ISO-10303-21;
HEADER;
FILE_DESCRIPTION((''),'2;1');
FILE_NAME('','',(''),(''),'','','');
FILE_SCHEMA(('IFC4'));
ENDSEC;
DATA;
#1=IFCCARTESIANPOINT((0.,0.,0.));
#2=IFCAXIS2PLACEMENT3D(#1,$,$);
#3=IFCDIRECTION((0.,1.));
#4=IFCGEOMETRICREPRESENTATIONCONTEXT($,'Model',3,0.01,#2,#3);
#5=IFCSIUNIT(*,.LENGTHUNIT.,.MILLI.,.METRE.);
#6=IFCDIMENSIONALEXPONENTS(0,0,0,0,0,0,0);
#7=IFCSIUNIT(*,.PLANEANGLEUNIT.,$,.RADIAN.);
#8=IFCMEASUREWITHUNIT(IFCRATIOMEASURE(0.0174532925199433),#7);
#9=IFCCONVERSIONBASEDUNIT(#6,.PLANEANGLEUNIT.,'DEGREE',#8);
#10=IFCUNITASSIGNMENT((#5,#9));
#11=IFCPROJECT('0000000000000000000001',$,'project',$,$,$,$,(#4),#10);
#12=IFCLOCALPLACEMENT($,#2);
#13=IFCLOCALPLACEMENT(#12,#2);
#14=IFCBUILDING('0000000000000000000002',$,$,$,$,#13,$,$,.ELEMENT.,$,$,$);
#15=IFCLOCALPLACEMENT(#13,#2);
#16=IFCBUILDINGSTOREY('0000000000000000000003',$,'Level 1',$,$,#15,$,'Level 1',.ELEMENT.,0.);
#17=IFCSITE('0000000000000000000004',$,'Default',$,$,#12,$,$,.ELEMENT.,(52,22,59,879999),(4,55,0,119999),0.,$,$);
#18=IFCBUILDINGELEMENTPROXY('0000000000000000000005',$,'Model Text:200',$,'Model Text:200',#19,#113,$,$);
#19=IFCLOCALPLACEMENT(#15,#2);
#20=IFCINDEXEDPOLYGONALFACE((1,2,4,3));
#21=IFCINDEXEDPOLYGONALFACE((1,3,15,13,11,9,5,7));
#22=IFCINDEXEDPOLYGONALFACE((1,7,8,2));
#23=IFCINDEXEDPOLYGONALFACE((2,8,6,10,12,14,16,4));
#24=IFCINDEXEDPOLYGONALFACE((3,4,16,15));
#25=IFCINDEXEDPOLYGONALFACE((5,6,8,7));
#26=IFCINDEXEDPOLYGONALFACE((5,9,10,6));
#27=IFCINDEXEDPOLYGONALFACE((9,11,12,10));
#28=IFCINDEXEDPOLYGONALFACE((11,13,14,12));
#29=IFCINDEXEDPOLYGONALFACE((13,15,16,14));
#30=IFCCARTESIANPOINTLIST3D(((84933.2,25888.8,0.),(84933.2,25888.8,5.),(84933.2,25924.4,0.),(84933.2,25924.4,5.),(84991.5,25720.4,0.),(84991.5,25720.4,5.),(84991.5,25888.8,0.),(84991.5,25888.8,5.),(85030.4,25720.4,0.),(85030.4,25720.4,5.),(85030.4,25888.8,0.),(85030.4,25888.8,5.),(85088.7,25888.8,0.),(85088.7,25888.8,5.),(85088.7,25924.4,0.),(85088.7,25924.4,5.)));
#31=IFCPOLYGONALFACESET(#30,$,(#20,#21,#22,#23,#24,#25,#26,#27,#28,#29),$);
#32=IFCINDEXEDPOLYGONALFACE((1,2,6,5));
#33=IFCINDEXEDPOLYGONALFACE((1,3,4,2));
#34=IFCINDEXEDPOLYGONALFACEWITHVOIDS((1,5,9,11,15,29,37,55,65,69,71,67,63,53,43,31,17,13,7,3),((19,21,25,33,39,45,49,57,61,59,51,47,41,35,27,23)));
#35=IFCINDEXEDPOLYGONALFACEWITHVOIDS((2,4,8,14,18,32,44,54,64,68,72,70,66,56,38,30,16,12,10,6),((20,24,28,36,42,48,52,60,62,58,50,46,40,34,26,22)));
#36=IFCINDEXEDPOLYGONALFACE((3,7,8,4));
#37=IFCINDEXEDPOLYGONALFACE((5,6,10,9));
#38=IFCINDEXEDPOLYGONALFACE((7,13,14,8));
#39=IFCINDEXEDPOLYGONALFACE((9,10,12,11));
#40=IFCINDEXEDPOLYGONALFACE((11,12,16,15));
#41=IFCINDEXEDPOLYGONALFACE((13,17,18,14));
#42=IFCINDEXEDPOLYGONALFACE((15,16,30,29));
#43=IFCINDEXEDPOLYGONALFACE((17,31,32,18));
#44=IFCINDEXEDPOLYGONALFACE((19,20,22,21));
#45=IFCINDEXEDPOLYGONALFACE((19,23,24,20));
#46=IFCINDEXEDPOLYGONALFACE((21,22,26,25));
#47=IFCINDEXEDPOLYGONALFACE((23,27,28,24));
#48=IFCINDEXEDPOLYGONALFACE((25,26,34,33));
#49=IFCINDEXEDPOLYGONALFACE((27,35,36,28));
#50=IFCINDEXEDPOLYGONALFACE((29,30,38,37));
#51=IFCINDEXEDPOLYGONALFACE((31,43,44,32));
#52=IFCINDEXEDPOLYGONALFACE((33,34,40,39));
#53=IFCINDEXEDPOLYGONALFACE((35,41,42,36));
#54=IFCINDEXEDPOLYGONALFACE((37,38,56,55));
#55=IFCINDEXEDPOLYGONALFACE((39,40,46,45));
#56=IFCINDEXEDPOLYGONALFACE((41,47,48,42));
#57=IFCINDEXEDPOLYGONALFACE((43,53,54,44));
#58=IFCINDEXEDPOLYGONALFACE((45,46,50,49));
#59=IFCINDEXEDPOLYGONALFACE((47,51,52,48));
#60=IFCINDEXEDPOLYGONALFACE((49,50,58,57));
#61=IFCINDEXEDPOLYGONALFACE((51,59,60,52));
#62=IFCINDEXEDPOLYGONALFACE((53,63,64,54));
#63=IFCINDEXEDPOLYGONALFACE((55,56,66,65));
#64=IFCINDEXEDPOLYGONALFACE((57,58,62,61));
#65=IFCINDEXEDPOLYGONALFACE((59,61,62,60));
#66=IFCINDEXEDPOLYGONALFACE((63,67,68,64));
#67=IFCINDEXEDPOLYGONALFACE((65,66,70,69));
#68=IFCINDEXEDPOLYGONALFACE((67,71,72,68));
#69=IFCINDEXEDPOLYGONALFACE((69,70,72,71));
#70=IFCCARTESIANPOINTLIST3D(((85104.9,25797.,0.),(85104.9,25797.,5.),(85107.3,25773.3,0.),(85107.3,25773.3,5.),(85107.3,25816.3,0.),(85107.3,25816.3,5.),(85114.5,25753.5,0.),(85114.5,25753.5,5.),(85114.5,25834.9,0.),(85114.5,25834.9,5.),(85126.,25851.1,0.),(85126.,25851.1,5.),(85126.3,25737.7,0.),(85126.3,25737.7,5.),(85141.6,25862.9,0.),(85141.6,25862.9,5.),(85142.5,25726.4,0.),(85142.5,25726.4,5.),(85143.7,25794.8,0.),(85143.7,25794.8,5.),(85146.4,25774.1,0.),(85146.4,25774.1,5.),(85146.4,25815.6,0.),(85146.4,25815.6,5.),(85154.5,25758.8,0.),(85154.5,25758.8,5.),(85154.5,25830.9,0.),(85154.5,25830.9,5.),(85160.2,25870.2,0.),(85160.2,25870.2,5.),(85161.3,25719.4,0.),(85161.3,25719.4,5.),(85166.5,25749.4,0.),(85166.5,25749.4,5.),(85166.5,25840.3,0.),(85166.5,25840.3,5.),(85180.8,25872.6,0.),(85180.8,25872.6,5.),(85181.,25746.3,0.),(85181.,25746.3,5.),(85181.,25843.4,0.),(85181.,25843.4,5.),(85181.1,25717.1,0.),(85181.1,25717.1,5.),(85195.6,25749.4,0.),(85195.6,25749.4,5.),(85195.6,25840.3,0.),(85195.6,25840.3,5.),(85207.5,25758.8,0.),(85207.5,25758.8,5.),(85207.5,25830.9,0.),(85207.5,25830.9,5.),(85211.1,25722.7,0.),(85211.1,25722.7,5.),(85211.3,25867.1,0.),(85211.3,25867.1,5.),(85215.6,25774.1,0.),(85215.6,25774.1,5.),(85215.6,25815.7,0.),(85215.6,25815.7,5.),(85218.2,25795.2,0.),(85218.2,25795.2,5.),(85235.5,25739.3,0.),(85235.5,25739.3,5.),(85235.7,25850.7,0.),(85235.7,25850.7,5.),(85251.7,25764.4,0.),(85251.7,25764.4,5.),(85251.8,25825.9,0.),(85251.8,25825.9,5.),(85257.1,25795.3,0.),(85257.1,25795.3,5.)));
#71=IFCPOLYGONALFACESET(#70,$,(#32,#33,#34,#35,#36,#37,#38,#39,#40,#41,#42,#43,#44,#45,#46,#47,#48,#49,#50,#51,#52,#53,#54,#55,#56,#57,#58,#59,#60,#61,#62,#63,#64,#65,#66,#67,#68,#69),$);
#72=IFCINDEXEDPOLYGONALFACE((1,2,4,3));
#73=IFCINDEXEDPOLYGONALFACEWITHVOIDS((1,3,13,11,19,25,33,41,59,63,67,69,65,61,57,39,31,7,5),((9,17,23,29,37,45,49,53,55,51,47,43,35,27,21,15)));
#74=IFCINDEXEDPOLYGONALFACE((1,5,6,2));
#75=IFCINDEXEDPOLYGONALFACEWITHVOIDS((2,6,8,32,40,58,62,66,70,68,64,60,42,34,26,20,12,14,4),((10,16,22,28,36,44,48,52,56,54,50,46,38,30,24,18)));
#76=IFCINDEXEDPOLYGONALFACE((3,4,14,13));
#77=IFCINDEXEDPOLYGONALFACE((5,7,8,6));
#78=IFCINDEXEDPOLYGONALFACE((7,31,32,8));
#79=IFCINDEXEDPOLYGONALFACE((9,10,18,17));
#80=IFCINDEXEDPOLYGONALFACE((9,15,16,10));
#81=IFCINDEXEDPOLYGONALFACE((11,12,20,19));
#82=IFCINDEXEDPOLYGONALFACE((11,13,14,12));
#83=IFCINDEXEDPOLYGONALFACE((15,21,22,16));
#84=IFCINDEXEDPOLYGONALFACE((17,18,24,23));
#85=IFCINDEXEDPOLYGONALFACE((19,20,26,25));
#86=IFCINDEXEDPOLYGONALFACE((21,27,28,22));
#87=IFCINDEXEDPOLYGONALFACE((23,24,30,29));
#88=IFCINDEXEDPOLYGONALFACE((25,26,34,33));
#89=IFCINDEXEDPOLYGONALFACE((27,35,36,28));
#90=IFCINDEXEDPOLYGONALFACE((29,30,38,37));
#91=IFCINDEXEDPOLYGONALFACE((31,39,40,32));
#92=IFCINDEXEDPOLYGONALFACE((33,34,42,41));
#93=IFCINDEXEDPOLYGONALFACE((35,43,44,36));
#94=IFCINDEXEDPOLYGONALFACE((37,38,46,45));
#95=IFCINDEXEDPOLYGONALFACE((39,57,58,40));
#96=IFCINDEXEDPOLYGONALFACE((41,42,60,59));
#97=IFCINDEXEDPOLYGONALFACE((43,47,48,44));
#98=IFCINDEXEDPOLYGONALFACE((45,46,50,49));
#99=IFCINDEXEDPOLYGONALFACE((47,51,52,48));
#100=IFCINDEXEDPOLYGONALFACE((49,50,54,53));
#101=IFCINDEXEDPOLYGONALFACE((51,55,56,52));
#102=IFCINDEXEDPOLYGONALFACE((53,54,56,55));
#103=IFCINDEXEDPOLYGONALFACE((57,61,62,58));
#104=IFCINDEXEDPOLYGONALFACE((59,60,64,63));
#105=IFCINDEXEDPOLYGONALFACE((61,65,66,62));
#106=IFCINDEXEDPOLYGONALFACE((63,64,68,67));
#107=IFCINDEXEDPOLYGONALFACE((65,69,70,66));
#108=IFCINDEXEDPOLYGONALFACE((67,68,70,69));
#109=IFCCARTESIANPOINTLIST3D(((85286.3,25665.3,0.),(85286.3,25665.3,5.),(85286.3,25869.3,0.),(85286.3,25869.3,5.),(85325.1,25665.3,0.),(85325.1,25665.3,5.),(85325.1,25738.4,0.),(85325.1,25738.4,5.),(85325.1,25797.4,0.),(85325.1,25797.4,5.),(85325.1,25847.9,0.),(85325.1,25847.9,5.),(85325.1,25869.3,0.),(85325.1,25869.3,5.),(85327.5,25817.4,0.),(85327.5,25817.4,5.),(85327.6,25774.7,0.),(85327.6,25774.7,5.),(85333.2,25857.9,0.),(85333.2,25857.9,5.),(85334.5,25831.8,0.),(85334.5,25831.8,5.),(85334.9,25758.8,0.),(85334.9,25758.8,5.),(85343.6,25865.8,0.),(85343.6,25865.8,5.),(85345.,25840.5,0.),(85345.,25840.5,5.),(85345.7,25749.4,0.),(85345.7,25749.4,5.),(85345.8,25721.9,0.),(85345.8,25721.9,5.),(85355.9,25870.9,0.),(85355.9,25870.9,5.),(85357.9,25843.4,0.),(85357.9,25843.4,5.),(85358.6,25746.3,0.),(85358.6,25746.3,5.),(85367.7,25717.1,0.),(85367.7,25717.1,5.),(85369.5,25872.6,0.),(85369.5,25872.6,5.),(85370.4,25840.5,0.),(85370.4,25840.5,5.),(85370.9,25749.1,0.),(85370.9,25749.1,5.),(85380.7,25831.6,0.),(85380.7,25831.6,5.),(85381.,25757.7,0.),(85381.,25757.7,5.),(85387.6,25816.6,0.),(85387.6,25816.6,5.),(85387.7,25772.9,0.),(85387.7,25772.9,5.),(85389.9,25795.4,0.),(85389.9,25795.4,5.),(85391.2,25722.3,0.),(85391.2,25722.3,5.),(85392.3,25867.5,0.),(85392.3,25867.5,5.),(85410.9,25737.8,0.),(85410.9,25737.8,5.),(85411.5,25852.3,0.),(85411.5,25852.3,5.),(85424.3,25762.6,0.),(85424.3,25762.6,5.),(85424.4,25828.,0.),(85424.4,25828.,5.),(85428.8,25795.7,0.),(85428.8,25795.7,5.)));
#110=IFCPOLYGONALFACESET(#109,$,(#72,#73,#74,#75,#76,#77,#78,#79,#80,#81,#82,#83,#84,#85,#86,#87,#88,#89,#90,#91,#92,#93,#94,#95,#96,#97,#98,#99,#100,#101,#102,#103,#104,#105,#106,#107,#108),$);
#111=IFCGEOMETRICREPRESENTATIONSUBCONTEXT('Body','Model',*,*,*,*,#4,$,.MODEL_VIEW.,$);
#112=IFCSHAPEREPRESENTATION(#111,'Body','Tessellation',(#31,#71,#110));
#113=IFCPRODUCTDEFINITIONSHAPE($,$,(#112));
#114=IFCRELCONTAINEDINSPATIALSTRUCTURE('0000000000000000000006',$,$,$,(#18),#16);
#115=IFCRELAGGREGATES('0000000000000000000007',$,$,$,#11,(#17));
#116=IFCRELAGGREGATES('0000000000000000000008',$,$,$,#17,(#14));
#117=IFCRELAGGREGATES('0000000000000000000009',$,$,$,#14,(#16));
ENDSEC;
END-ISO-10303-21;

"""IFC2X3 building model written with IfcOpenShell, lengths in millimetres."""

from ifc_helpers import new_model, entity, si_unit, converted_unit, direction, frame, origin, place, context, subcontext, project, spatial, polyline, outline, extrude, element, save


model = new_model("IFC2X3")

# Units and contexts
model_context = context("Model", 3, precision=0.01, world=origin(), true_north=direction((0.0, 1.0)))
body_context = subcontext(model_context, "Body", "Model", "MODEL_VIEW")
ifc_project = project(units=[si_unit("LENGTHUNIT", "METRE", prefix="MILLI"), converted_unit("PLANEANGLEUNIT", "DEGREE", entity("IfcRatioMeasure", 0.0174532925199433), si_unit("PLANEANGLEUNIT", "RADIAN"), dimensions=[0, 0, 0, 0, 0, 0, 0])], contexts=[model_context])

# Site, building, storey
site_placement = place(None, origin())
site = spatial("IfcSite", under=ifc_project, at=site_placement, Name="Default", CompositionType="ELEMENT", RefLatitude=(52, 22, 59, 879999), RefLongitude=(4, 55, 0, 119999), RefElevation=0.0)
building_placement = place(site_placement, origin())
building = spatial("IfcBuilding", under=site, at=building_placement, CompositionType="ELEMENT")
storey_placement = place(building_placement, origin())
storey = spatial("IfcBuildingStorey", under=building, at=storey_placement, Name="Level 1", LongName="Level 1", CompositionType="ELEMENT", Elevation=0.0)

# Building element proxy
proxy_1_placement = place(building_placement, origin())
element("IfcBuildingElementProxy", 1, at=proxy_1_placement, inside=storey, Name="Model Text:200", ObjectType="Model Text:200", context=body_context, shape_type="SweptSolid", body=[
    extrude(outline(polyline([(-19.4, -135.2), (19.4, -135.2), (19.4, 33.2), (77.7, 33.2), (77.7, 68.8), (-77.7, 68.8), (-77.7, 33.2), (-19.4, 33.2), (-19.4, -135.2)])), frame((85010.9, 25855.6, 0.0)), (0.0, 0.0, 1.0), 5.0),
    extrude(outline(polyline([(-8.8, -65.7), (15.1, -65.7), (35.5, -60.5), (52.3, -50.4), (65.3, -35.4), (74.1, -17.3), (78.4, 2.1), (75.9, 32.5), (61.8, 58.5), (38.4, 77.1), (8.3, 85.6), (-22.7, 83.3), (-49.0, 69.9), (-67.8, 47.3), (-76.3, 17.5), (-76.0, -3.3), (-70.7, -22.5), (-60.5, -39.2), (-45.5, -52.3), (-27.7, -61.4), (-8.8, -65.7)]), holes=[polyline([(-2.7, -27.2), (-23.1, -22.5), (-37.5, -12.9), (-45.7, 0.0), (-47.3, 14.8), (-42.7, 28.9), (-32.2, 39.9), (-16.3, 46.3), (4.5, 46.9), (25.1, 42.1), (39.6, 32.6), (47.7, 19.7), (49.4, 5.0), (44.8, -9.2), (34.2, -20.2), (18.2, -26.7), (-2.7, -27.2)])]), frame((85171.1, 25794.9, 0.0), z_axis=(0.0, 0.0, 1.0), x_axis=(0.100608, -0.994926, 0.0)), (0.0, 0.0, 1.0), 5.0),
    extrude(outline(polyline([(-73.1, -75.4), (130.9, -75.4), (130.9, -36.6), (57.8, -36.6), (74.3, -15.9), (79.1, 6.0), (73.9, 29.5), (58.4, 49.2), (33.6, 62.6), (0.5, 67.1), (-31.8, 62.8), (-56.1, 49.8), (-71.3, 30.7), (-76.4, 7.8), (-74.7, -5.8), (-69.6, -18.1), (-61.7, -28.5), (-51.7, -36.6), (-73.1, -36.6), (-73.1, -75.4)]), holes=[polyline([(-1.2, -36.6), (-21.2, -34.2), (-35.6, -27.2), (-44.3, -16.7), (-47.2, -3.8), (-44.3, 8.7), (-35.4, 19.0), (-20.4, 25.9), (0.8, 28.2), (23.3, 26.0), (38.5, 19.3), (47.1, 9.2), (49.9, -3.1), (46.8, -16.0), (37.4, -26.8), (21.5, -34.1), (-1.2, -36.6)])]), frame((85361.7, 25796.2, 0.0), z_axis=(0.0, 0.0, 1.0), x_axis=(0.0, -1.0, 0.0)), (0.0, 0.0, 1.0), 5.0),
])

save(model, "model.ifc")
